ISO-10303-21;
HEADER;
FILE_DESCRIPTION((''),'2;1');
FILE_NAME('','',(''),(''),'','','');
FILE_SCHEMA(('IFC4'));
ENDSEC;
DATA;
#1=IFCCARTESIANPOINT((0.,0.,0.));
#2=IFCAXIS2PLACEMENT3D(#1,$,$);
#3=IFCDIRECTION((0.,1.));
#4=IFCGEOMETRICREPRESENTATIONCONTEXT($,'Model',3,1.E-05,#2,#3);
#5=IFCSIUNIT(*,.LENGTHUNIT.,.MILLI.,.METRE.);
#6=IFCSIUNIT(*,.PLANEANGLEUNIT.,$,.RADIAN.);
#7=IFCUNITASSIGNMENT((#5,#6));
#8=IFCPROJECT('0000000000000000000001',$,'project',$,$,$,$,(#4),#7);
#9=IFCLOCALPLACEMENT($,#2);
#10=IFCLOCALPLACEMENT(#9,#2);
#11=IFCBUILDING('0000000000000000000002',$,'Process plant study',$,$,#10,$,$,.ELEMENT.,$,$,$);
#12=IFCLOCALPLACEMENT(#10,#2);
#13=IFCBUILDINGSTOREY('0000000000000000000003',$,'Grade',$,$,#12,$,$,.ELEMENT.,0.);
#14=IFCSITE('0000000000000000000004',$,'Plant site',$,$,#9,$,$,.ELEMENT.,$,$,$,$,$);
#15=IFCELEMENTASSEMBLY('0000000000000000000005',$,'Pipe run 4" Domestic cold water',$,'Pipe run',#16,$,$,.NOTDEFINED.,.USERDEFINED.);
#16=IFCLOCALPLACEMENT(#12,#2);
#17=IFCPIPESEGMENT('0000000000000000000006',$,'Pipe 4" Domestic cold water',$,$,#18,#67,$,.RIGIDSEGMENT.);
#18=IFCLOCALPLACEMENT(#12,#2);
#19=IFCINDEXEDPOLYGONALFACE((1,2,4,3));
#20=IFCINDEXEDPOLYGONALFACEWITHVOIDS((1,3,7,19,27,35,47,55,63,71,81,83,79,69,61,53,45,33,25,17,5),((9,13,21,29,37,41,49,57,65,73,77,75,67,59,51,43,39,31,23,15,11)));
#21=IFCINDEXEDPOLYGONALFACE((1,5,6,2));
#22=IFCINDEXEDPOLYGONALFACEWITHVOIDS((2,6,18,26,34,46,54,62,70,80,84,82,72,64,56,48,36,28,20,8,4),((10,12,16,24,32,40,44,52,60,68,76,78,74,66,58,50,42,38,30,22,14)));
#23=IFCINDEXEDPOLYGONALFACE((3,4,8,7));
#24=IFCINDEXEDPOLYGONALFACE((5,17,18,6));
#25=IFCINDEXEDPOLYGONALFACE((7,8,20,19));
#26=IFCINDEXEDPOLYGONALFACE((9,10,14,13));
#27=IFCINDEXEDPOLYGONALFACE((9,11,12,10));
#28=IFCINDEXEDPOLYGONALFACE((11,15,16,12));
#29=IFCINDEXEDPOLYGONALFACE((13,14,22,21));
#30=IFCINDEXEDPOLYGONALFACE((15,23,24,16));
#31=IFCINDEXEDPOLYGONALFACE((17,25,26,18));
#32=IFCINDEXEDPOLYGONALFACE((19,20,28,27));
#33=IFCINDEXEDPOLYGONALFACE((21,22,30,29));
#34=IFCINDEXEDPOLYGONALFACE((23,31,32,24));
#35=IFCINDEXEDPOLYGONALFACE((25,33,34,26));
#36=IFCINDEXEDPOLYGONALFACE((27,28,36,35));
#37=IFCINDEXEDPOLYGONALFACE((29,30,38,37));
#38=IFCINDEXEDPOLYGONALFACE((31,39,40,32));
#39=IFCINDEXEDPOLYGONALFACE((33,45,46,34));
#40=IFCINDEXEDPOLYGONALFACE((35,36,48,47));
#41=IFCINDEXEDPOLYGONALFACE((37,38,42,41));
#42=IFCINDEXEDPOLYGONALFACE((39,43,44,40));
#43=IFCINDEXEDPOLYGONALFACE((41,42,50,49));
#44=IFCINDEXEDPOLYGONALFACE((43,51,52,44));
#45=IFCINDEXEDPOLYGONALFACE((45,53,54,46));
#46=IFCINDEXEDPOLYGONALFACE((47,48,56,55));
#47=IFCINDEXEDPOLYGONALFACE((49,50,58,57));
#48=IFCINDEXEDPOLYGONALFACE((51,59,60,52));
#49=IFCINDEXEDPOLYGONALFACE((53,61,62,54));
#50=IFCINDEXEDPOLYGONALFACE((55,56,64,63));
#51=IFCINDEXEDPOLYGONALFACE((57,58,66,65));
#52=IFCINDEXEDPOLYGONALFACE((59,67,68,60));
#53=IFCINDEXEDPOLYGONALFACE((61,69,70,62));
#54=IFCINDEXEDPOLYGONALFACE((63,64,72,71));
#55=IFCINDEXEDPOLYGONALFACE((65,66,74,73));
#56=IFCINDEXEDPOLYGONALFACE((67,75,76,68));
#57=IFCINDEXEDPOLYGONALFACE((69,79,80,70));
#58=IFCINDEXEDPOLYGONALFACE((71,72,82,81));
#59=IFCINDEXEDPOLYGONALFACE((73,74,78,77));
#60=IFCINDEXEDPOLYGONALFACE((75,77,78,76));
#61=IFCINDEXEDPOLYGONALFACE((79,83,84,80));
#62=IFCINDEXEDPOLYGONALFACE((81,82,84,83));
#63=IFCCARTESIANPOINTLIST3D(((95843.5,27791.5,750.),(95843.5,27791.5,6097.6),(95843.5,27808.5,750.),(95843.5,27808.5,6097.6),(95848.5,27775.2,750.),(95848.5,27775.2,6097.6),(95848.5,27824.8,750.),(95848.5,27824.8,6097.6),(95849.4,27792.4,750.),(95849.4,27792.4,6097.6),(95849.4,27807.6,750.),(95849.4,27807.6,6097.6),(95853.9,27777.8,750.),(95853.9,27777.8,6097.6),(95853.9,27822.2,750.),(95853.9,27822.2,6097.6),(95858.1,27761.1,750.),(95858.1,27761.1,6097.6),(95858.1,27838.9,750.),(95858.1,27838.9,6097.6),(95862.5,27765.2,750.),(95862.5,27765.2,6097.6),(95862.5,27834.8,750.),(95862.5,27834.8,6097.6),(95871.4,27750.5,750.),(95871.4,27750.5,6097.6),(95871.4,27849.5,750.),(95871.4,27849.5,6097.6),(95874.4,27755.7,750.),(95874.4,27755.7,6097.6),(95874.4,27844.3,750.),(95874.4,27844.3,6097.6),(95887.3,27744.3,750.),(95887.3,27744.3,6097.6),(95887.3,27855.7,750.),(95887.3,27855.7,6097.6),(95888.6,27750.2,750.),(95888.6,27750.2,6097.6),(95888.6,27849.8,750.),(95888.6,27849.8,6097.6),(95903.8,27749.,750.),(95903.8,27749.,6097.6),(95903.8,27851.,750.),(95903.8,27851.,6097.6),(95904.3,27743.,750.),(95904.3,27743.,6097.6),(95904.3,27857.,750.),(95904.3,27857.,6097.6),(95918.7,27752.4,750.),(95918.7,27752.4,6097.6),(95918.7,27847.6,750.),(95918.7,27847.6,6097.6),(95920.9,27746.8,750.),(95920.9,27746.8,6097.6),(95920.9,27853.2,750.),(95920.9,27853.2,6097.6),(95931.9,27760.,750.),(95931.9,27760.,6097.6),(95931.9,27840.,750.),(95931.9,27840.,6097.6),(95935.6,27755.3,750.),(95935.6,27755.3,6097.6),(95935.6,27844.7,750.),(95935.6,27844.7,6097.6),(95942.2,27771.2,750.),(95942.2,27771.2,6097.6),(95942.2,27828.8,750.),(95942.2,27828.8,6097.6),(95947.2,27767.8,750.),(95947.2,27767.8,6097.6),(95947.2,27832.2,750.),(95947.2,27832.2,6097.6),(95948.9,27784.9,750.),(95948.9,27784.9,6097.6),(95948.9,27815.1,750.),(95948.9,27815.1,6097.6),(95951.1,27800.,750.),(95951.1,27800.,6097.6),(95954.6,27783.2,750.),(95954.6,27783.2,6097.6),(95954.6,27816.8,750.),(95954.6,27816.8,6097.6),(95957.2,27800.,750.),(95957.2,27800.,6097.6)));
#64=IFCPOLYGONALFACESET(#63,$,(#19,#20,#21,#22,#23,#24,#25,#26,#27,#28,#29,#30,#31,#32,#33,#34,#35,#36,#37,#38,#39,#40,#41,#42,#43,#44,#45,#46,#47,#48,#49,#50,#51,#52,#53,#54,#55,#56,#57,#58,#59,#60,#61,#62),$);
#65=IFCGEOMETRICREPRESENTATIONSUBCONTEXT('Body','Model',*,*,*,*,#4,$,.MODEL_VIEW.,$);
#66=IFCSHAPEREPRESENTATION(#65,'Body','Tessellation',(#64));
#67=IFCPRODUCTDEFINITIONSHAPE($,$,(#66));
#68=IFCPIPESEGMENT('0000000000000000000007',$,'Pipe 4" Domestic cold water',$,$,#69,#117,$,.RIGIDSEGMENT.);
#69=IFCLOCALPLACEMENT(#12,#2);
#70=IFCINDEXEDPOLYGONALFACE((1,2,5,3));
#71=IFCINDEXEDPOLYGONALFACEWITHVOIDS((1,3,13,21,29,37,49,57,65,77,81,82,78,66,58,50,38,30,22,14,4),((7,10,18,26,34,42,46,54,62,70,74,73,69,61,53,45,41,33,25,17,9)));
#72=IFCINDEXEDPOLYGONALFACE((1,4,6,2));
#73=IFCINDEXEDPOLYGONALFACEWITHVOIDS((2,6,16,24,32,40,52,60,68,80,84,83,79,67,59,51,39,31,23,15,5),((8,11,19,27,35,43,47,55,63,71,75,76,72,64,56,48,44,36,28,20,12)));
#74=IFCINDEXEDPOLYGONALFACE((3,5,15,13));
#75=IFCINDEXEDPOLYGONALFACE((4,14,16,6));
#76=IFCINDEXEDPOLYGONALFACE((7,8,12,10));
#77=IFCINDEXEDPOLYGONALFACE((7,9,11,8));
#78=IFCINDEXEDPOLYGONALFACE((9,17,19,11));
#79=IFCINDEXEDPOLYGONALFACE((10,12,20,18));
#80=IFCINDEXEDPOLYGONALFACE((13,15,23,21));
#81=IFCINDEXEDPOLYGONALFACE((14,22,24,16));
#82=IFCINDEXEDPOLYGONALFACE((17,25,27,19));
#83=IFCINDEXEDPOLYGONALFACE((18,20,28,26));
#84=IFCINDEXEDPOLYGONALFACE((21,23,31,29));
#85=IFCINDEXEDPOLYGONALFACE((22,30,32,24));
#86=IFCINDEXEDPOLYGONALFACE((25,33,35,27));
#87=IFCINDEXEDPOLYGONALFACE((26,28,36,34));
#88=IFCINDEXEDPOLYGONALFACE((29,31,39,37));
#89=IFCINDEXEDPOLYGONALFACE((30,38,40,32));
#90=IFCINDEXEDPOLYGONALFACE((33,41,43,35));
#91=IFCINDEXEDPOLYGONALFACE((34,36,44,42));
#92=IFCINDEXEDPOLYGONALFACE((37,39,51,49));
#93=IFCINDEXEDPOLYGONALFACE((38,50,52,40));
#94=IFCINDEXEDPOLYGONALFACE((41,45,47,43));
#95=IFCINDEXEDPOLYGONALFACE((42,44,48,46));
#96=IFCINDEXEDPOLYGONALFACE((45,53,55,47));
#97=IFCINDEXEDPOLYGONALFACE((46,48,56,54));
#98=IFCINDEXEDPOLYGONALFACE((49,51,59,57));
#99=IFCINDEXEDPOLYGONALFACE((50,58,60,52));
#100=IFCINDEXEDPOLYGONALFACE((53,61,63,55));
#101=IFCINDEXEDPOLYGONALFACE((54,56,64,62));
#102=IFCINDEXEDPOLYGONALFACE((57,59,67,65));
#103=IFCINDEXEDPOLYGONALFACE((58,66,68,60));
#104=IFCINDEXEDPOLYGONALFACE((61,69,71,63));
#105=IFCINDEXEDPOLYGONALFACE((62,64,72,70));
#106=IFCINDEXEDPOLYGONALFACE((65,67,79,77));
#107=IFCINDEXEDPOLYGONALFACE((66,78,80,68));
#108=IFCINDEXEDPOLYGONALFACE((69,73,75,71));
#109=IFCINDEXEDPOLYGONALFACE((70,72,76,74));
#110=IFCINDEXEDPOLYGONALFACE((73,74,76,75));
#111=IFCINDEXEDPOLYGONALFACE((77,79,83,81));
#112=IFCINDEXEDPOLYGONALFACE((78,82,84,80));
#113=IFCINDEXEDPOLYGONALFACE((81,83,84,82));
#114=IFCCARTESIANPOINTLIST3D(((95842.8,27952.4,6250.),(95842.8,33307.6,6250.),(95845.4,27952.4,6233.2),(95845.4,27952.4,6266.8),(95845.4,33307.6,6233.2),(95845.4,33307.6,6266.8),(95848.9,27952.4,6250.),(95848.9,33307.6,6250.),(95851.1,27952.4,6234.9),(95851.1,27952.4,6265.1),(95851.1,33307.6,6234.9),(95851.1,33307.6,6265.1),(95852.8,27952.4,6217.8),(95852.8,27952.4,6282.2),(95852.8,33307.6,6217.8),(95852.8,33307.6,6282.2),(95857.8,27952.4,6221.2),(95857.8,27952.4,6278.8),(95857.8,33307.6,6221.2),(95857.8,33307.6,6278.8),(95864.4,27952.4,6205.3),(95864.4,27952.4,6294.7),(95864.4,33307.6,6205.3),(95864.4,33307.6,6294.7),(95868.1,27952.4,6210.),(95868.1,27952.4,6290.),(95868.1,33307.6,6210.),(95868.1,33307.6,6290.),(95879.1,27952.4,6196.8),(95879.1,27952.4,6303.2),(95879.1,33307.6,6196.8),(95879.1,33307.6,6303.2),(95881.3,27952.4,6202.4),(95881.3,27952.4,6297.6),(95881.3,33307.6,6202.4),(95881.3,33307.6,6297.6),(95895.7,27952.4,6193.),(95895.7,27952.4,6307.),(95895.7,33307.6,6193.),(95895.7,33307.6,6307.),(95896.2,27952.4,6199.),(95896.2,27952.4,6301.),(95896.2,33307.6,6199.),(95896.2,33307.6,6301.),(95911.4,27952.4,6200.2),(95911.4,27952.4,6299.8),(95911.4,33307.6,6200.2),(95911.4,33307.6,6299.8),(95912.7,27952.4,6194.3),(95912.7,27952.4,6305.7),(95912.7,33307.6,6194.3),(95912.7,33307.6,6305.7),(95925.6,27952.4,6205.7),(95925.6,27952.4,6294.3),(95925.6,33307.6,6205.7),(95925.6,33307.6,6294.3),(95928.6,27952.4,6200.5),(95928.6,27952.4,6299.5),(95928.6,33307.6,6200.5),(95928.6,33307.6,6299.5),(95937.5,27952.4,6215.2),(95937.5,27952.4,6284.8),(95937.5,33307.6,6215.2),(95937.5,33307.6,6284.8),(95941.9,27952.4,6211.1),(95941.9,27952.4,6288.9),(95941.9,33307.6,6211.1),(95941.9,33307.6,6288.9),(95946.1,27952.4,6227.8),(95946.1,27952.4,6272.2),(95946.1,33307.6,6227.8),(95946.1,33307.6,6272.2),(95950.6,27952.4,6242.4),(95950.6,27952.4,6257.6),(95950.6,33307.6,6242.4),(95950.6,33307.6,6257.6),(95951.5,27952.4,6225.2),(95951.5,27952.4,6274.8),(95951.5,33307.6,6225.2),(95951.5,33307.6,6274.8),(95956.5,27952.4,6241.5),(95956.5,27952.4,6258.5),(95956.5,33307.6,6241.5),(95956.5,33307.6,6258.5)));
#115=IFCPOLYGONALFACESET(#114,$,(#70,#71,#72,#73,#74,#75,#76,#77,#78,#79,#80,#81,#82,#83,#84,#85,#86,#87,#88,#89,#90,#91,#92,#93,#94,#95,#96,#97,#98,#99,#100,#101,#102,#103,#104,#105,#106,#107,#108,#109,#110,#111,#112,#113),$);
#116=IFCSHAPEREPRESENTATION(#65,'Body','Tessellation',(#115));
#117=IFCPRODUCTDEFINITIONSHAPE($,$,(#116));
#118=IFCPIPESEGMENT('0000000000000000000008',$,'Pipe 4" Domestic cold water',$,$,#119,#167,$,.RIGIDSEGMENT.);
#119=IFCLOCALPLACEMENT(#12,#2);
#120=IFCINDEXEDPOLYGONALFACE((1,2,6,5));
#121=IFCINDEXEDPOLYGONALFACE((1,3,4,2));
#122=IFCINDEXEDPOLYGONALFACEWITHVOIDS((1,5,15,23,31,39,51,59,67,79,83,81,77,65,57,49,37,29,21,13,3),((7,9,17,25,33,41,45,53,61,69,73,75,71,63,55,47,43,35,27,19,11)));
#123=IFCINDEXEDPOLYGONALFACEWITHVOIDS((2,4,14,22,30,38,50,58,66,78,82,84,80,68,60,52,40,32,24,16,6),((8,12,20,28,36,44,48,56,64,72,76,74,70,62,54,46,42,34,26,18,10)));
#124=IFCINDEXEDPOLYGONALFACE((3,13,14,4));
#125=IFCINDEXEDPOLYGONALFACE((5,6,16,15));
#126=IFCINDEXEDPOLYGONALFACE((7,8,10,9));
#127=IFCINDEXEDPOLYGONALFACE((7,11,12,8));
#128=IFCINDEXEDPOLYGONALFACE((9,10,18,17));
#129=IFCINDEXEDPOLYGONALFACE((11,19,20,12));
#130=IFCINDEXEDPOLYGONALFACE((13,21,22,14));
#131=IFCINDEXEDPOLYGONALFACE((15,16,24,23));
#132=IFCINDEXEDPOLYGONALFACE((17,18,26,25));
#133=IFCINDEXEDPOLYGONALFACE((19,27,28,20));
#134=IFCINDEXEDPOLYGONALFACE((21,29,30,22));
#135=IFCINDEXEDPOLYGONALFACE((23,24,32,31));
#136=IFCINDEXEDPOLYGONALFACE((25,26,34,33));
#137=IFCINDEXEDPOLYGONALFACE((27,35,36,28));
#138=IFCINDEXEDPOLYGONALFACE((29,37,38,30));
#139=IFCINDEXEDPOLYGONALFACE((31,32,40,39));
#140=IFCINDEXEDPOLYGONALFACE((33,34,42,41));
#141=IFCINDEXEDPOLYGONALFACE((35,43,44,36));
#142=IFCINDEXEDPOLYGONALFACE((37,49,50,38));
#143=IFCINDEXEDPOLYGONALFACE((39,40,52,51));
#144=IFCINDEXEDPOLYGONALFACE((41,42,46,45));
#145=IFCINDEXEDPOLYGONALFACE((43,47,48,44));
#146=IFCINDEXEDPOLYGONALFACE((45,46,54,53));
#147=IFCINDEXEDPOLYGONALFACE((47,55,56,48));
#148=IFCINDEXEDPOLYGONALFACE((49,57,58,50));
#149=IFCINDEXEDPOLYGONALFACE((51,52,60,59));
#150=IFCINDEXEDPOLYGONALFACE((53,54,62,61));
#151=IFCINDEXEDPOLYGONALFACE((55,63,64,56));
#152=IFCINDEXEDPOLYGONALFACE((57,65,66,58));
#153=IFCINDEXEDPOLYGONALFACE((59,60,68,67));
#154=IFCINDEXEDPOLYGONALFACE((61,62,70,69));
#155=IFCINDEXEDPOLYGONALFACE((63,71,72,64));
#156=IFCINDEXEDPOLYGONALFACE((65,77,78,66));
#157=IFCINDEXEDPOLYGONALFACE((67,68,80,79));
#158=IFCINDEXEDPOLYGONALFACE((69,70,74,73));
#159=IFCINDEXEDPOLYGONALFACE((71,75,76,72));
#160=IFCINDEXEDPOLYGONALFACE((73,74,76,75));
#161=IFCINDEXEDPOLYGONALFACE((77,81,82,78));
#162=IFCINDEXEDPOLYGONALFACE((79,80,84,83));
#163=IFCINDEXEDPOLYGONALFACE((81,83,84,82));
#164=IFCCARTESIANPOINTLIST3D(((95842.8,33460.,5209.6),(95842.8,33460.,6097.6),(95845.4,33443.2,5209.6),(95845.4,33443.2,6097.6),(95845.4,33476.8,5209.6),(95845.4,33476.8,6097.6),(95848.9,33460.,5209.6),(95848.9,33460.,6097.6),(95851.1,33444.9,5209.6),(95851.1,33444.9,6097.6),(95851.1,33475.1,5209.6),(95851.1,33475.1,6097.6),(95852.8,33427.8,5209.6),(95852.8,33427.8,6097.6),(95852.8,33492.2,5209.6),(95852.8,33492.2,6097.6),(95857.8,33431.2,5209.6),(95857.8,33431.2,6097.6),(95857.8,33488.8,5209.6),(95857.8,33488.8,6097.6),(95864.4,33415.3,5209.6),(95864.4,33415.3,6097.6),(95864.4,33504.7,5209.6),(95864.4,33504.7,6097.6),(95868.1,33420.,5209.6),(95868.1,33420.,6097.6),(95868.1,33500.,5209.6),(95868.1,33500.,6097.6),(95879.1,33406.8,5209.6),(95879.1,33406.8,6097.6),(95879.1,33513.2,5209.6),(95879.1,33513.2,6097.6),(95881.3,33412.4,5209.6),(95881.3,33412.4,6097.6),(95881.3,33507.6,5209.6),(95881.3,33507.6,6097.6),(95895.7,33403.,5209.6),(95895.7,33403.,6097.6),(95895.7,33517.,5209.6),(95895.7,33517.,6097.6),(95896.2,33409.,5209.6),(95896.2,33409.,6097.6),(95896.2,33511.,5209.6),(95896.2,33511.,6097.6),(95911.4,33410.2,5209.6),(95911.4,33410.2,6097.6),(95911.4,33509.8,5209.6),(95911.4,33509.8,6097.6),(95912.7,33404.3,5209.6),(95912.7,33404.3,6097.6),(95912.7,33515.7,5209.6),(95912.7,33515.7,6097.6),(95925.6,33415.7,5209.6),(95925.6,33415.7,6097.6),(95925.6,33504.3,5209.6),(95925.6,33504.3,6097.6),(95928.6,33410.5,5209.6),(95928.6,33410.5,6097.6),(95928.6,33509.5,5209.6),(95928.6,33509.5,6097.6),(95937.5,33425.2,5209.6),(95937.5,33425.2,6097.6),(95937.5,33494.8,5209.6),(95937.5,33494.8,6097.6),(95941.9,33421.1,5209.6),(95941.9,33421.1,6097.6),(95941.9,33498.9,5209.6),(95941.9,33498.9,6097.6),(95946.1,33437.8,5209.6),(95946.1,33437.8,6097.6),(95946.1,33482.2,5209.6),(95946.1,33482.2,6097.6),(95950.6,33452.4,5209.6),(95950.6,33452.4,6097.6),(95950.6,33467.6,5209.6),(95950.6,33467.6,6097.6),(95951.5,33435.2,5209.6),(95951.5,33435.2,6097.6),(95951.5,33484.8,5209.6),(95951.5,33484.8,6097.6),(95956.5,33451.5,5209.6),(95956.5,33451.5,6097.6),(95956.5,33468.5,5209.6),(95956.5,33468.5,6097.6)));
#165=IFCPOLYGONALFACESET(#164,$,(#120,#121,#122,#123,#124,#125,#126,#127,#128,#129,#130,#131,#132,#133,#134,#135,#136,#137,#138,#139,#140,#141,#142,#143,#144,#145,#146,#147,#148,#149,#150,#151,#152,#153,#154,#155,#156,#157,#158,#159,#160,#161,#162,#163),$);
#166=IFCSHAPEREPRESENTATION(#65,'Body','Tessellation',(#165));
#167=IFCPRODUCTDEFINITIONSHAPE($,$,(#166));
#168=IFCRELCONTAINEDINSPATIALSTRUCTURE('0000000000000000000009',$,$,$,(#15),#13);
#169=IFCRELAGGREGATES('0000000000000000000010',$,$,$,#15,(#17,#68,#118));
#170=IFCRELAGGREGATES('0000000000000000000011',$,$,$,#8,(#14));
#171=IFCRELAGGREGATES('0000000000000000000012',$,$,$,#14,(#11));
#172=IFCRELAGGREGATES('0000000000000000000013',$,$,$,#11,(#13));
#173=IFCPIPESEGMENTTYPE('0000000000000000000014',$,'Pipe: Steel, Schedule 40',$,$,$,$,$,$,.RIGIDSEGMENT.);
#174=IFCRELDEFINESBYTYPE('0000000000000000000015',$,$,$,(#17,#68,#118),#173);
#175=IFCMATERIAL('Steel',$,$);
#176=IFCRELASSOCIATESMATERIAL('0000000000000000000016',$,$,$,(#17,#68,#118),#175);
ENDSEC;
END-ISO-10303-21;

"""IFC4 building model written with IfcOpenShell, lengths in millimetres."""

from ifc_helpers import new_model, si_unit, direction, frame, origin, origin_with_axes, origin_2d, place, context, subcontext, project, spatial, hollow_circle, extrude, material, type_object, element, aggregate, save


model = new_model("IFC4")

# Units and contexts
model_context = context("Model", 3, precision=1e-05, world=origin(), true_north=direction((0.0, 1.0)))
body_context = subcontext(model_context, "Body", "Model", "MODEL_VIEW")
ifc_project = project(units=[si_unit("LENGTHUNIT", "METRE", prefix="MILLI"), si_unit("PLANEANGLEUNIT", "RADIAN")], contexts=[model_context])

# Site, building, storey
site_placement = place(None, origin())
site = spatial("IfcSite", under=ifc_project, at=site_placement, Name="Plant site", CompositionType="ELEMENT")
building_placement = place(site_placement, origin())
building = spatial("IfcBuilding", under=site, at=building_placement, Name="Process plant study", CompositionType="ELEMENT")
storey_placement = place(building_placement, origin())
storey = spatial("IfcBuildingStorey", under=building, at=storey_placement, Name="Grade", CompositionType="ELEMENT", Elevation=0.0)

# Element assembly, pipe segments
ifc_material = material(Name="Steel")
pipe_segment_type = type_object("IfcPipeSegmentType", Name="Pipe: Steel, Schedule 40", PredefinedType="RIGIDSEGMENT")
assembly_1_placement = place(storey_placement, origin_with_axes())
assembly_1 = element("IfcElementAssembly", 1, at=assembly_1_placement, inside=storey, Name="Pipe run 4\" Domestic cold water", ObjectType="Pipe run", AssemblyPlace="NOTDEFINED", PredefinedType="USERDEFINED")
pipe_segment_1_placement = place(storey_placement, origin_with_axes())
pipe_segment_1 = element("IfcPipeSegment", 2, at=pipe_segment_1_placement, type_object=pipe_segment_type, material=ifc_material, Name="Pipe 4\" Domestic cold water", PredefinedType="RIGIDSEGMENT", context=body_context, shape_type="SweptSolid", body=[
    extrude(hollow_circle(Radius=57.1, WallThickness=6.0, at=origin_2d()), frame((95900.0, 27800.0, 750.0), z_axis=(0.0, 0.0, 1.0), x_axis=(1.0, 0.0, 0.0)), (0.0, 0.0, 1.0), 5347.6),
])
pipe_segment_2_placement = place(storey_placement, origin_with_axes())
pipe_segment_2 = element("IfcPipeSegment", 3, at=pipe_segment_2_placement, type_object=pipe_segment_type, material=ifc_material, Name="Pipe 4\" Domestic cold water", PredefinedType="RIGIDSEGMENT", context=body_context, shape_type="SweptSolid", body=[
    extrude(hollow_circle(Radius=57.1, WallThickness=6.0, at=origin_2d()), frame((95900.0, 27952.4, 6250.0), z_axis=(0.0, 1.0, 0.0), x_axis=(-1.0, 0.0, 0.0)), (0.0, 0.0, 1.0), 5355.2),
])
pipe_segment_3_placement = place(storey_placement, origin_with_axes())
pipe_segment_3 = element("IfcPipeSegment", 4, at=pipe_segment_3_placement, type_object=pipe_segment_type, material=ifc_material, Name="Pipe 4\" Domestic cold water", PredefinedType="RIGIDSEGMENT", context=body_context, shape_type="SweptSolid", body=[
    extrude(hollow_circle(Radius=57.1, WallThickness=6.0, at=origin_2d()), frame((95900.0, 33460.0, 6097.6), z_axis=(0.0, 0.0, -1.0), x_axis=(-1.0, 0.0, 0.0)), (0.0, 0.0, 1.0), 888.0),
])

aggregate(assembly_1, [pipe_segment_1, pipe_segment_2, pipe_segment_3])

save(model, "model.ifc")
